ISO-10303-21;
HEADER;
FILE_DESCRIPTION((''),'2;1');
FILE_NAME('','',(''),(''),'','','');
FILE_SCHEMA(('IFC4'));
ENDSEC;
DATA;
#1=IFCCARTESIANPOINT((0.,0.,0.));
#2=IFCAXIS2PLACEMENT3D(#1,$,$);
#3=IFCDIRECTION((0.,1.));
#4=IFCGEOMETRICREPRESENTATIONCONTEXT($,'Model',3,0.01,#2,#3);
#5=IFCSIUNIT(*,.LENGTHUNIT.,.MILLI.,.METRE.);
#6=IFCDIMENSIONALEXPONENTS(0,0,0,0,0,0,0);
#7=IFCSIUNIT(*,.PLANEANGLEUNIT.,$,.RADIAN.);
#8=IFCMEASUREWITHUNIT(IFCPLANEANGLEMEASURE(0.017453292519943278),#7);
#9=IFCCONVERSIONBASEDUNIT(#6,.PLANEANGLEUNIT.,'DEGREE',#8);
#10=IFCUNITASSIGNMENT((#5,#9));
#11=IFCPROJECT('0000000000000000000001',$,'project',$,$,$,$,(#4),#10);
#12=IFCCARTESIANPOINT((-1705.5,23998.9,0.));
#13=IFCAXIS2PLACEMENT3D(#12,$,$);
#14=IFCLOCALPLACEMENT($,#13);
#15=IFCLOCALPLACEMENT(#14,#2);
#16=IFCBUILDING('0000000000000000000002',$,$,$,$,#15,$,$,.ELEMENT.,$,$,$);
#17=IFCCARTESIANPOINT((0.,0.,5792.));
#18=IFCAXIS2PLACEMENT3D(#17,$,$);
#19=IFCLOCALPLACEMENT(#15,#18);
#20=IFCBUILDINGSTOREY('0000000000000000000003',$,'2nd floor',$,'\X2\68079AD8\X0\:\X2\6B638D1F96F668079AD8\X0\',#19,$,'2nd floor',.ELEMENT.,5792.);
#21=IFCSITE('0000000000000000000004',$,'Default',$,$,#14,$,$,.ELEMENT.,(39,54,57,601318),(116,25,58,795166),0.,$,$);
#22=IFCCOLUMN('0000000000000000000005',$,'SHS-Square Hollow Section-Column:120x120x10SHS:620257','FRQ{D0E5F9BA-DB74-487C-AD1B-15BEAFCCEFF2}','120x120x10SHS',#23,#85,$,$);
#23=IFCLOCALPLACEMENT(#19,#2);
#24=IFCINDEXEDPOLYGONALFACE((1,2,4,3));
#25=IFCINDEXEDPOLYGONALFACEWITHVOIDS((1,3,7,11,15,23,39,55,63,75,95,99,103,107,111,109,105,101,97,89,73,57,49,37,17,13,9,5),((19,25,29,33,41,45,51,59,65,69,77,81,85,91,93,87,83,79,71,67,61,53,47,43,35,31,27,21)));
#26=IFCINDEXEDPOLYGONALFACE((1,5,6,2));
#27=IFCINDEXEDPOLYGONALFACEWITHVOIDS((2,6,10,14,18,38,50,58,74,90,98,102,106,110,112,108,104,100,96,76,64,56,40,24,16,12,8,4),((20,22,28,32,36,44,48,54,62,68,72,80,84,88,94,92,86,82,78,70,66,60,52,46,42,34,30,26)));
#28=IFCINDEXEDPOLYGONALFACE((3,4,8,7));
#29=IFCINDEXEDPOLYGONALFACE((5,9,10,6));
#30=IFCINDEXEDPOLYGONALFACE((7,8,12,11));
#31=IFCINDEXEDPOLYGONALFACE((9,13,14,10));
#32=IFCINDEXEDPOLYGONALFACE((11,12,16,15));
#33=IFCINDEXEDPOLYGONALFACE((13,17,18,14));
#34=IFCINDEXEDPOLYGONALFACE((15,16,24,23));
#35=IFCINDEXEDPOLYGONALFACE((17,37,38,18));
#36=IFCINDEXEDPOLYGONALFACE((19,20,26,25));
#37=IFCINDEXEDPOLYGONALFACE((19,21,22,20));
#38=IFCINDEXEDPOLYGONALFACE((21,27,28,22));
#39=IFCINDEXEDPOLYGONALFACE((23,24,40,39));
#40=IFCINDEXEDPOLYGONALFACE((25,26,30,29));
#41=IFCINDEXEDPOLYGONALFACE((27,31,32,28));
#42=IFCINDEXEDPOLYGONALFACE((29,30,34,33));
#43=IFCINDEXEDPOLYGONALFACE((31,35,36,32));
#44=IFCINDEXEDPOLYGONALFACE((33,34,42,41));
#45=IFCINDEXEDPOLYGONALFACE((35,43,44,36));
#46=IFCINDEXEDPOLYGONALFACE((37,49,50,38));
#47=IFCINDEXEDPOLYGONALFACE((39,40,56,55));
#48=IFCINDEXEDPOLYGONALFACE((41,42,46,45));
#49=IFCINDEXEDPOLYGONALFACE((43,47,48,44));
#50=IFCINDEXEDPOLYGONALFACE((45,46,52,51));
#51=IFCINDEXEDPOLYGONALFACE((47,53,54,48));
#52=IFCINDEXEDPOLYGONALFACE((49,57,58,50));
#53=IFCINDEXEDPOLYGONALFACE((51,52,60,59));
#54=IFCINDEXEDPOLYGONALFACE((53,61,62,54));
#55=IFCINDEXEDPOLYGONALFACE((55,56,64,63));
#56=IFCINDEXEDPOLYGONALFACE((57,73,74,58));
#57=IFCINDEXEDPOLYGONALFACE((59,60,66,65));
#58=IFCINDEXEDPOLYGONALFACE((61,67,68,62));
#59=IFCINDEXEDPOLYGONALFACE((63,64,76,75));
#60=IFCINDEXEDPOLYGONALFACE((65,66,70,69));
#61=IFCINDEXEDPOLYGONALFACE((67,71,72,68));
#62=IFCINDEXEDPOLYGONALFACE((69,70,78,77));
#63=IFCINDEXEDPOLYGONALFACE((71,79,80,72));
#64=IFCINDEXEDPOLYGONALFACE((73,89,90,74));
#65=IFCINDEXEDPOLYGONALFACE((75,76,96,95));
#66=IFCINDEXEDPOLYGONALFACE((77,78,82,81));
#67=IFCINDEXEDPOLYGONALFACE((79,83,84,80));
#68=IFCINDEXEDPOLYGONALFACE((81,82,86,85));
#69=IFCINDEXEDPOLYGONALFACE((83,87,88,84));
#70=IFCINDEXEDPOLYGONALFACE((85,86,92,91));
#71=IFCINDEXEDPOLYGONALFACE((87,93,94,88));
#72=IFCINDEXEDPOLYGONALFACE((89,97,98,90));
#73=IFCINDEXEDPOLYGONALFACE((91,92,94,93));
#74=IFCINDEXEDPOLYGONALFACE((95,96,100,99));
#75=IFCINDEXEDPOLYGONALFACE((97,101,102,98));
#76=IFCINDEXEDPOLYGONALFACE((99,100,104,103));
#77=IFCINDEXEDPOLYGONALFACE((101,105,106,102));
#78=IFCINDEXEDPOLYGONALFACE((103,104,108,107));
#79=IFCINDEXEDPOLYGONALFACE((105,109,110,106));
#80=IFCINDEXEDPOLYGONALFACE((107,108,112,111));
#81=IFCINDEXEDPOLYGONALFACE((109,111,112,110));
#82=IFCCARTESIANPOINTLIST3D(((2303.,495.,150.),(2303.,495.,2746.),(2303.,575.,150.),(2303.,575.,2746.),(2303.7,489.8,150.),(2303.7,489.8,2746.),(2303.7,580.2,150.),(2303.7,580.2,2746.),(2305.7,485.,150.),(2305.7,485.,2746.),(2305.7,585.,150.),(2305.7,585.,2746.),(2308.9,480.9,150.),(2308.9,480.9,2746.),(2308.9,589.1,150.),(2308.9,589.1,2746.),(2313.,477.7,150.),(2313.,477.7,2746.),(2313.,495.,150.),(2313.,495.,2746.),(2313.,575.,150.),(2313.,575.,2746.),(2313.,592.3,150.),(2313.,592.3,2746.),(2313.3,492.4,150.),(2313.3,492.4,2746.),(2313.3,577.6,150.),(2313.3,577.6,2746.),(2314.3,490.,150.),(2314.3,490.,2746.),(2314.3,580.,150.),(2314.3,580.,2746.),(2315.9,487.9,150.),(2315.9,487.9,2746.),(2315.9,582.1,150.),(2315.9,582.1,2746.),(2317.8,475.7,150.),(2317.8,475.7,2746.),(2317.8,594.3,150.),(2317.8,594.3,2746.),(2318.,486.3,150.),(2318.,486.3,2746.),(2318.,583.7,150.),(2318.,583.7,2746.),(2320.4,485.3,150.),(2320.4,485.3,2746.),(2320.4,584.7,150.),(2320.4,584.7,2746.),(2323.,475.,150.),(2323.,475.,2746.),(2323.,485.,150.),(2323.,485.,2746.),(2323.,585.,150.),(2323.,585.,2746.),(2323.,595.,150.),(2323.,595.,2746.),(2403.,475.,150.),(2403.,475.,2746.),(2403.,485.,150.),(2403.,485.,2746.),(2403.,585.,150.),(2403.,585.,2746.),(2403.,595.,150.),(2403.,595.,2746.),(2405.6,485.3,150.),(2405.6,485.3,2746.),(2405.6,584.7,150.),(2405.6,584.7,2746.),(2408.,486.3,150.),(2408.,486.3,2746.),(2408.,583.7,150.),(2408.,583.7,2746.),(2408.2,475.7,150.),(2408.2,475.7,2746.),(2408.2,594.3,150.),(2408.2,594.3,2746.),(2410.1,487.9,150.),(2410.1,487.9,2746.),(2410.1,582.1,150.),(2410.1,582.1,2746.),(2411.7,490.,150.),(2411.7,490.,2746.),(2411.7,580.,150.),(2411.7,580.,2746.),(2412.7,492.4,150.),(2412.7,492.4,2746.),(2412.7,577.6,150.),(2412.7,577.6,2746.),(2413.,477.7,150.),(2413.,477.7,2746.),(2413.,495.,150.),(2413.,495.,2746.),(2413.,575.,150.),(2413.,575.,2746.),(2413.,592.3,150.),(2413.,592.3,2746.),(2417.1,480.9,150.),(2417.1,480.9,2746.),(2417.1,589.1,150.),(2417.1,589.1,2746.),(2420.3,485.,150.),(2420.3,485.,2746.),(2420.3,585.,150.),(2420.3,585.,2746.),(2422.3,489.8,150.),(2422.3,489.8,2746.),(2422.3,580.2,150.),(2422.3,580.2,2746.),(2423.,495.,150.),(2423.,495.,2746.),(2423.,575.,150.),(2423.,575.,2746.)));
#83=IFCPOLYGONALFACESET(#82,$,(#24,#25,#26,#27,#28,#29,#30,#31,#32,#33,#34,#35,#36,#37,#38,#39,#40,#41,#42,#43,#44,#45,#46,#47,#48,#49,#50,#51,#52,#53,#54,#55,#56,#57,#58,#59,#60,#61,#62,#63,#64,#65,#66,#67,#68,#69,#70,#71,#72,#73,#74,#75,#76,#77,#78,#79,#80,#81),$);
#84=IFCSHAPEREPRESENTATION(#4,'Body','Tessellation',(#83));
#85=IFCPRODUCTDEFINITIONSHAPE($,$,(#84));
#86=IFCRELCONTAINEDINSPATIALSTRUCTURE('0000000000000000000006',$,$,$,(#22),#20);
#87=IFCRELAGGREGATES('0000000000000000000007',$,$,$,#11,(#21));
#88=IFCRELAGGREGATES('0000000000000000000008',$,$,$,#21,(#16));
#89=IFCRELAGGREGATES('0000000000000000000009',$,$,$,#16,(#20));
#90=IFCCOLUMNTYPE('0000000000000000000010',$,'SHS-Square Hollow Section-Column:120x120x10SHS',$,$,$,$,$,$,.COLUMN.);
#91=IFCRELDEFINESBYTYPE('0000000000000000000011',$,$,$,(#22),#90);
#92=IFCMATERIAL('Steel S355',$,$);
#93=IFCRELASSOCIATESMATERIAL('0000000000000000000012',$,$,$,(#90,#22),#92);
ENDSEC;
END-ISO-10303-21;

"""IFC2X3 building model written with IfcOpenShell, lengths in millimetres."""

from ifc_helpers import new_model, entity, si_unit, converted_unit, direction, frame, origin, origin_2d, place, context, project, spatial, hollow_rectangle, extrude, clip, halfspace, material, type_object, element, save


model = new_model("IFC2X3")

# Units and contexts
model_context = context("Model", 3, precision=0.01, world=origin(), true_north=direction((0.0, 1.0)))
ifc_project = project(units=[si_unit("LENGTHUNIT", "METRE", prefix="MILLI"), converted_unit("PLANEANGLEUNIT", "DEGREE", entity("IfcPlaneAngleMeasure", 0.017453292519943278), si_unit("PLANEANGLEUNIT", "RADIAN"), dimensions=[0, 0, 0, 0, 0, 0, 0])], contexts=[model_context])

# Site, building, storey
site_placement = place(None, frame((-1705.5, 23998.9, 0.0)))
site = spatial("IfcSite", under=ifc_project, at=site_placement, Name="Default", CompositionType="ELEMENT", RefLatitude=(39, 54, 57, 601318), RefLongitude=(116, 25, 58, 795166), RefElevation=0.0)
building_placement = place(site_placement, origin())
building = spatial("IfcBuilding", under=site, at=building_placement, CompositionType="ELEMENT")
storey_placement = place(building_placement, frame((0.0, 0.0, 5792.0)))
storey = spatial("IfcBuildingStorey", under=building, at=storey_placement, Name="2nd floor", ObjectType="标高:正负零标高", LongName="2nd floor", CompositionType="ELEMENT", Elevation=5792.0)

# Column
ifc_material_1 = material(Name="Steel S355")
column_type_1 = type_object("IfcColumnType", Name="SHS-Square Hollow Section-Column:120x120x10SHS", PredefinedType="COLUMN", material=ifc_material_1)
column_1_placement = place(storey_placement, frame((2363.0, 535.0, 2746.0), z_axis=(0.0, 0.0, 1.0), x_axis=(0.0, -1.0, 0.0)))
element("IfcColumn", 1, at=column_1_placement, inside=storey, type_object=column_type_1, material=ifc_material_1, Name="SHS-Square Hollow Section-Column:120x120x10SHS:620257", Description="FRQ{D0E5F9BA-DB74-487C-AD1B-15BEAFCCEFF2}", ObjectType="120x120x10SHS", context=model_context, shape_type="Clipping", body=[
    clip(extrude(hollow_rectangle(XDim=120.0, YDim=120.0, WallThickness=10.0, InnerFilletRadius=10.0, OuterFilletRadius=20.0, at=origin_2d()), origin(), (0.0, 0.0, -1.0), 2680.9), halfspace(frame((535.0, -2363.0, -2596.0), z_axis=(0.0, 0.0, 1.0), x_axis=(0.0, 1.0, 0.0)), True)),
])

save(model, "model.ifc")
